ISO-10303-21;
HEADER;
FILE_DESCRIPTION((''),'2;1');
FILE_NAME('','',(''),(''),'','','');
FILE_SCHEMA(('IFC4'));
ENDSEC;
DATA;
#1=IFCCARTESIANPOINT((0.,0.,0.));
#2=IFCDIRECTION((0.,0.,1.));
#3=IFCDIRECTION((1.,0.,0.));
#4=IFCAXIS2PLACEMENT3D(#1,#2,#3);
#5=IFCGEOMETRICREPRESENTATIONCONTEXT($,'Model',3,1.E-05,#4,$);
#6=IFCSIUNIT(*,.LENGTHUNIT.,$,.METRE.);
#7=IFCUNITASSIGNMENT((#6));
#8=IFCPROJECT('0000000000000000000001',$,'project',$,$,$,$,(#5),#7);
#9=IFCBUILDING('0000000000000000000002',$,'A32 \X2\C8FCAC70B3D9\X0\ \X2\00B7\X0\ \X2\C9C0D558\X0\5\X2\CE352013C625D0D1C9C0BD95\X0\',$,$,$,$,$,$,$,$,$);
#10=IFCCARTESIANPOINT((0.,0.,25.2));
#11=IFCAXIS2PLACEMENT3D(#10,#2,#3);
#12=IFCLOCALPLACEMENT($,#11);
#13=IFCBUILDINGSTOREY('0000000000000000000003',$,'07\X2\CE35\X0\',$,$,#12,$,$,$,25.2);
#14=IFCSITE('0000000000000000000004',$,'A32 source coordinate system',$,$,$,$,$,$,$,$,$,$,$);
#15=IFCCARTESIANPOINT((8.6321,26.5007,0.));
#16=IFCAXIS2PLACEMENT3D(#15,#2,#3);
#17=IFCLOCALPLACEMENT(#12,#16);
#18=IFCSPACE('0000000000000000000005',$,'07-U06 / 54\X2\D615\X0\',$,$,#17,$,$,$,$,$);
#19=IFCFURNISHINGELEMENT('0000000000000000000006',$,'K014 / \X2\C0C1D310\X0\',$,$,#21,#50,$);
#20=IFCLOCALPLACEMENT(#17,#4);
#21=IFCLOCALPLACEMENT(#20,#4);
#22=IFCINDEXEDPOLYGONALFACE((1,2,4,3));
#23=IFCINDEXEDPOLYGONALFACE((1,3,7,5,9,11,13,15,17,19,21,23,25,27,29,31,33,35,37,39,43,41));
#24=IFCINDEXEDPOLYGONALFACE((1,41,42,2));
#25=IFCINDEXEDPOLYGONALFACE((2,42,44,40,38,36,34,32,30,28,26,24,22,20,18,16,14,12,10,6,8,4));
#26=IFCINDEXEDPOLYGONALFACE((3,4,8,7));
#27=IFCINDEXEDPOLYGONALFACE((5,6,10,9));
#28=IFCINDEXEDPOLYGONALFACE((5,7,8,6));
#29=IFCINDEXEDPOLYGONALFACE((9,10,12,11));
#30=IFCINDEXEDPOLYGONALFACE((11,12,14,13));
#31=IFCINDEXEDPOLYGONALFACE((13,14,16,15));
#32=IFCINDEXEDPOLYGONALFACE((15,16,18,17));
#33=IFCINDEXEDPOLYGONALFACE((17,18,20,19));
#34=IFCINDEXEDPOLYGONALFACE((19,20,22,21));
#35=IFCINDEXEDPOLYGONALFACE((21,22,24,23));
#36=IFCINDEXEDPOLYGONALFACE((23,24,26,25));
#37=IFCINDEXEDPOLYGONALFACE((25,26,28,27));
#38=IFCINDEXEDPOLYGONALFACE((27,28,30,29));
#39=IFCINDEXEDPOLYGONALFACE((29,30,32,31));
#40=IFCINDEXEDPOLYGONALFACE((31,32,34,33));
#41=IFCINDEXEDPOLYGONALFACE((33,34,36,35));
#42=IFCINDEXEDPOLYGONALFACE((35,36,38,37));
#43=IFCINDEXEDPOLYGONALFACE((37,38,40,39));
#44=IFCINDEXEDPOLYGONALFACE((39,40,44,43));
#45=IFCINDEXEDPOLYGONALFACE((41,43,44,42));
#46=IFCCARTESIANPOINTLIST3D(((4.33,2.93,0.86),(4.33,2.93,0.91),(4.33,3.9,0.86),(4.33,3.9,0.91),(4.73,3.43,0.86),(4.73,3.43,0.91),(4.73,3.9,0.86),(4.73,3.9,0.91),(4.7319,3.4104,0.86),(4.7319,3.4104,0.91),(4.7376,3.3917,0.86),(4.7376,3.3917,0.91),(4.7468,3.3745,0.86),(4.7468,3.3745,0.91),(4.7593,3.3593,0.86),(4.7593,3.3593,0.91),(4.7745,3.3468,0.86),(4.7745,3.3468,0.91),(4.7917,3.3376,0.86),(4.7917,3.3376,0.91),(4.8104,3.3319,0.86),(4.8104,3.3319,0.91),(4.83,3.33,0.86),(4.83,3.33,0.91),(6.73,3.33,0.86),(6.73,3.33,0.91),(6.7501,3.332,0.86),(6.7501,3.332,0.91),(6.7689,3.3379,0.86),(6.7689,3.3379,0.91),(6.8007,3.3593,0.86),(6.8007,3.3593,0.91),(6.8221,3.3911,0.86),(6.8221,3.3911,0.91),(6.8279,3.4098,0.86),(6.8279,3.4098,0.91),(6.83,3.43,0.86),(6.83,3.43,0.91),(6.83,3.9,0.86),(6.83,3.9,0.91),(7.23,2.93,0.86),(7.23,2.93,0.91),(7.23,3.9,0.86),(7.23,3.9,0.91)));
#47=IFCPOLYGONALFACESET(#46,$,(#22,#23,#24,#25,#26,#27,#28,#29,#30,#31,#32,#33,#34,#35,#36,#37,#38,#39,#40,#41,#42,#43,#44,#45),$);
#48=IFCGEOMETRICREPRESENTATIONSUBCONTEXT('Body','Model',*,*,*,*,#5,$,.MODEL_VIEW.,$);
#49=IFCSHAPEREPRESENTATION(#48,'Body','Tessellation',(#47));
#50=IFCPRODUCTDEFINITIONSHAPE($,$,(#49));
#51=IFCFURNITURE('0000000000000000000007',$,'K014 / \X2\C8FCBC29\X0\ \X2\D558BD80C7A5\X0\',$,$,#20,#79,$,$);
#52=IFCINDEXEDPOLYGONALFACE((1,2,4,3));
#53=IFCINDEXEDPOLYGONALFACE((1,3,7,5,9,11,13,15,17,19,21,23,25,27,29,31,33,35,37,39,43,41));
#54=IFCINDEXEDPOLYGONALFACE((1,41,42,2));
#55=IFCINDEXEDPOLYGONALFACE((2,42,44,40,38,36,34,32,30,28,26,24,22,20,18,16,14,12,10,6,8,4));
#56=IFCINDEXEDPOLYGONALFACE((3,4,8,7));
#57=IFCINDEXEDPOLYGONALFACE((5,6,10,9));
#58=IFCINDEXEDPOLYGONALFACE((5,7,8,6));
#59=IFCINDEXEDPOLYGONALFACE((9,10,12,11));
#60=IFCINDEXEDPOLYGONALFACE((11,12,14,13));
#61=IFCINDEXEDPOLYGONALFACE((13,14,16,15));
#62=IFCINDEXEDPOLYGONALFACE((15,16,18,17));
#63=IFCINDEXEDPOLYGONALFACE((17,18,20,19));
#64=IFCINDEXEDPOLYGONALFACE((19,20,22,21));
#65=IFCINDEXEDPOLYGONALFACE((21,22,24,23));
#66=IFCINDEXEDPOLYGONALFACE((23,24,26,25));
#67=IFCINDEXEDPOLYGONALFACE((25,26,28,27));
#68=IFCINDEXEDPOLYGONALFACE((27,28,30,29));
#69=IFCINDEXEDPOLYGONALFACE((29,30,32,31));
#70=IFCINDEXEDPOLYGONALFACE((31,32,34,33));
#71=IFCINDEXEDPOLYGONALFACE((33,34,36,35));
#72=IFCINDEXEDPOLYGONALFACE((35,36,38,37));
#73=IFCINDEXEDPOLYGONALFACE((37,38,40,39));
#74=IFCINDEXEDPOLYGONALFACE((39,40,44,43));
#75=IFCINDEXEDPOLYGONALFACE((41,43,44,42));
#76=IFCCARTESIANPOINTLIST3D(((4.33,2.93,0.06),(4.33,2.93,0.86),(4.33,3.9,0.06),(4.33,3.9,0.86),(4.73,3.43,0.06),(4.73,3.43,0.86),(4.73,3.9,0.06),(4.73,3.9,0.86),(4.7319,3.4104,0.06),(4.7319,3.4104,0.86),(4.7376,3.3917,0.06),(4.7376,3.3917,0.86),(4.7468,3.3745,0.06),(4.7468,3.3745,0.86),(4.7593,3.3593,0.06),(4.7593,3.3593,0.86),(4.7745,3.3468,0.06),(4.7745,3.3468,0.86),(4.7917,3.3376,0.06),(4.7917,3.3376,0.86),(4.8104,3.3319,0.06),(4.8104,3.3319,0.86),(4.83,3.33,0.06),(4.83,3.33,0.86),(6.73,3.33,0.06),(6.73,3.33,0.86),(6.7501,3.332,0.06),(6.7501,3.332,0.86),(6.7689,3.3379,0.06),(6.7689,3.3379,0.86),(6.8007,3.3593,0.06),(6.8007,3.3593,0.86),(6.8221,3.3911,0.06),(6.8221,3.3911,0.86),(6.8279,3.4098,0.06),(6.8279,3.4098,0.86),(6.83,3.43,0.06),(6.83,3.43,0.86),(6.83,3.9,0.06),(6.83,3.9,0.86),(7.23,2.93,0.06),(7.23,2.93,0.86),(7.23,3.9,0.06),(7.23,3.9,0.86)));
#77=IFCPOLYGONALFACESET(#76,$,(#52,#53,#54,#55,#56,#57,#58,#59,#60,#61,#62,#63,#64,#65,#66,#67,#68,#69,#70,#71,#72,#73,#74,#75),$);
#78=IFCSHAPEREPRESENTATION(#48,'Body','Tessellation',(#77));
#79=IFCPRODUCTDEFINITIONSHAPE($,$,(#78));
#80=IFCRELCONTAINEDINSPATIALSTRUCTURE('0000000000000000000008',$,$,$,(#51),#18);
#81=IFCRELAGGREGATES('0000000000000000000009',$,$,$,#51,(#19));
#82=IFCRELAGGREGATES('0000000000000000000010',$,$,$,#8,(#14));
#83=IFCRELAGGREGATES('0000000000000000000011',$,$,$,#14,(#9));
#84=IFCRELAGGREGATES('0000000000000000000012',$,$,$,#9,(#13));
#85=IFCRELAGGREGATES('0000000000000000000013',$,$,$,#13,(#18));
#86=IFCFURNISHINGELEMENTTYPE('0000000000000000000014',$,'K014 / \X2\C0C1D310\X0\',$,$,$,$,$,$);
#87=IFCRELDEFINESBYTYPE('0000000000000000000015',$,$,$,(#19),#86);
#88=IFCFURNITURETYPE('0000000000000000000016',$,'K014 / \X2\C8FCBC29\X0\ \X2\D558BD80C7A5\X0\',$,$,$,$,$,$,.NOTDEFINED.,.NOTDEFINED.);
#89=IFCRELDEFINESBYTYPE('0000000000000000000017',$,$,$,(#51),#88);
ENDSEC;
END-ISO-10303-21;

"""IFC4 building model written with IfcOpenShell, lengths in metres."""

from ifc_helpers import new_model, si_unit, frame, origin, origin_with_axes, place, context, subcontext, project, spatial, polyline, outline, extrude, source, transform, mapped, type_object, type_shapes, element, aggregate, save


model = new_model("IFC4")

# Units and contexts
model_context = context("Model", 3, precision=1e-05, world=origin_with_axes())
body_context = subcontext(model_context, "Body", "Model", "MODEL_VIEW")
ifc_project = project(units=[si_unit("LENGTHUNIT", "METRE")], contexts=[model_context])

# Site, building, storey, space
site = spatial("IfcSite", under=ifc_project, Name="A32 source coordinate system")
building = spatial("IfcBuilding", under=site, Name="A32 주거동 · 지하5층–옥탑지붕")
storey_placement = place(None, frame((0.0, 0.0, 25.2), z_axis=(0.0, 0.0, 1.0), x_axis=(1.0, 0.0, 0.0)))
storey = spatial("IfcBuildingStorey", under=building, at=storey_placement, Name="07층", Elevation=25.2)
space_placement = place(storey_placement, frame((8.6321, 26.5007, 0.0), z_axis=(0.0, 0.0, 1.0), x_axis=(1.0, 0.0, 0.0)))
space = spatial("IfcSpace", under=storey, at=space_placement, Name="07-U06 / 54형")

# Furnishing element
furnishing_element_type_1 = type_object("IfcFurnishingElementType", Name="K014 / 상판")
shared_shape_1 = source(origin(), body_context, "Body", "SweptSolid", [
    extrude(outline(polyline([(4.33, 2.93), (4.33, 3.9), (4.73, 3.9), (4.73, 3.43), (4.7319, 3.4104), (4.7376, 3.3917), (4.7468, 3.3745), (4.7593, 3.3593), (4.7745, 3.3468), (4.7917, 3.3376), (4.8104, 3.3319), (4.83, 3.33), (6.73, 3.33), (6.7501, 3.332), (6.7689, 3.3379), (6.8007, 3.3593), (6.8221, 3.3911), (6.8279, 3.4098), (6.83, 3.43), (6.83, 3.9), (7.23, 3.9), (7.23, 2.93), (4.33, 2.93)])), frame((0.0, 0.0, 0.86)), (0.0, 0.0, 1.0), 0.05),
])
type_shapes(furnishing_element_type_1, [shared_shape_1])
furniture_1_placement = place(space_placement, origin_with_axes())
furnishing_1_placement = place(furniture_1_placement, origin_with_axes())
furnishing_1 = element("IfcFurnishingElement", 1, at=furnishing_1_placement, type_object=furnishing_element_type_1, Name="K014 / 상판", context=body_context, shape_type="MappedRepresentation", body=[
    mapped(shared_shape_1, transform((0.0, 0.0, 0.0), scale=1.0)),
])

# Furniture
furniture_type_1 = type_object("IfcFurnitureType", Name="K014 / 주방 하부장", AssemblyPlace="NOTDEFINED", PredefinedType="NOTDEFINED")
shared_shape_2 = source(origin(), body_context, "Body", "SweptSolid", [
    extrude(outline(polyline([(7.23, 2.93), (4.33, 2.93), (4.33, 3.9), (4.73, 3.9), (4.73, 3.43), (4.7319, 3.4104), (4.7376, 3.3917), (4.7468, 3.3745), (4.7593, 3.3593), (4.7745, 3.3468), (4.7917, 3.3376), (4.8104, 3.3319), (4.83, 3.33), (6.73, 3.33), (6.7501, 3.332), (6.7689, 3.3379), (6.8007, 3.3593), (6.8221, 3.3911), (6.8279, 3.4098), (6.83, 3.43), (6.83, 3.9), (7.23, 3.9), (7.23, 2.93)])), frame((0.0, 0.0, 0.06)), (0.0, 0.0, 1.0), 0.8),
])
type_shapes(furniture_type_1, [shared_shape_2])
furniture_1 = element("IfcFurniture", 2, at=furniture_1_placement, inside=space, type_object=furniture_type_1, Name="K014 / 주방 하부장", context=body_context, shape_type="MappedRepresentation", body=[
    mapped(shared_shape_2, transform((0.0, 0.0, 0.0), scale=1.0)),
])
aggregate(furniture_1, [furnishing_1])

save(model, "model.ifc")
